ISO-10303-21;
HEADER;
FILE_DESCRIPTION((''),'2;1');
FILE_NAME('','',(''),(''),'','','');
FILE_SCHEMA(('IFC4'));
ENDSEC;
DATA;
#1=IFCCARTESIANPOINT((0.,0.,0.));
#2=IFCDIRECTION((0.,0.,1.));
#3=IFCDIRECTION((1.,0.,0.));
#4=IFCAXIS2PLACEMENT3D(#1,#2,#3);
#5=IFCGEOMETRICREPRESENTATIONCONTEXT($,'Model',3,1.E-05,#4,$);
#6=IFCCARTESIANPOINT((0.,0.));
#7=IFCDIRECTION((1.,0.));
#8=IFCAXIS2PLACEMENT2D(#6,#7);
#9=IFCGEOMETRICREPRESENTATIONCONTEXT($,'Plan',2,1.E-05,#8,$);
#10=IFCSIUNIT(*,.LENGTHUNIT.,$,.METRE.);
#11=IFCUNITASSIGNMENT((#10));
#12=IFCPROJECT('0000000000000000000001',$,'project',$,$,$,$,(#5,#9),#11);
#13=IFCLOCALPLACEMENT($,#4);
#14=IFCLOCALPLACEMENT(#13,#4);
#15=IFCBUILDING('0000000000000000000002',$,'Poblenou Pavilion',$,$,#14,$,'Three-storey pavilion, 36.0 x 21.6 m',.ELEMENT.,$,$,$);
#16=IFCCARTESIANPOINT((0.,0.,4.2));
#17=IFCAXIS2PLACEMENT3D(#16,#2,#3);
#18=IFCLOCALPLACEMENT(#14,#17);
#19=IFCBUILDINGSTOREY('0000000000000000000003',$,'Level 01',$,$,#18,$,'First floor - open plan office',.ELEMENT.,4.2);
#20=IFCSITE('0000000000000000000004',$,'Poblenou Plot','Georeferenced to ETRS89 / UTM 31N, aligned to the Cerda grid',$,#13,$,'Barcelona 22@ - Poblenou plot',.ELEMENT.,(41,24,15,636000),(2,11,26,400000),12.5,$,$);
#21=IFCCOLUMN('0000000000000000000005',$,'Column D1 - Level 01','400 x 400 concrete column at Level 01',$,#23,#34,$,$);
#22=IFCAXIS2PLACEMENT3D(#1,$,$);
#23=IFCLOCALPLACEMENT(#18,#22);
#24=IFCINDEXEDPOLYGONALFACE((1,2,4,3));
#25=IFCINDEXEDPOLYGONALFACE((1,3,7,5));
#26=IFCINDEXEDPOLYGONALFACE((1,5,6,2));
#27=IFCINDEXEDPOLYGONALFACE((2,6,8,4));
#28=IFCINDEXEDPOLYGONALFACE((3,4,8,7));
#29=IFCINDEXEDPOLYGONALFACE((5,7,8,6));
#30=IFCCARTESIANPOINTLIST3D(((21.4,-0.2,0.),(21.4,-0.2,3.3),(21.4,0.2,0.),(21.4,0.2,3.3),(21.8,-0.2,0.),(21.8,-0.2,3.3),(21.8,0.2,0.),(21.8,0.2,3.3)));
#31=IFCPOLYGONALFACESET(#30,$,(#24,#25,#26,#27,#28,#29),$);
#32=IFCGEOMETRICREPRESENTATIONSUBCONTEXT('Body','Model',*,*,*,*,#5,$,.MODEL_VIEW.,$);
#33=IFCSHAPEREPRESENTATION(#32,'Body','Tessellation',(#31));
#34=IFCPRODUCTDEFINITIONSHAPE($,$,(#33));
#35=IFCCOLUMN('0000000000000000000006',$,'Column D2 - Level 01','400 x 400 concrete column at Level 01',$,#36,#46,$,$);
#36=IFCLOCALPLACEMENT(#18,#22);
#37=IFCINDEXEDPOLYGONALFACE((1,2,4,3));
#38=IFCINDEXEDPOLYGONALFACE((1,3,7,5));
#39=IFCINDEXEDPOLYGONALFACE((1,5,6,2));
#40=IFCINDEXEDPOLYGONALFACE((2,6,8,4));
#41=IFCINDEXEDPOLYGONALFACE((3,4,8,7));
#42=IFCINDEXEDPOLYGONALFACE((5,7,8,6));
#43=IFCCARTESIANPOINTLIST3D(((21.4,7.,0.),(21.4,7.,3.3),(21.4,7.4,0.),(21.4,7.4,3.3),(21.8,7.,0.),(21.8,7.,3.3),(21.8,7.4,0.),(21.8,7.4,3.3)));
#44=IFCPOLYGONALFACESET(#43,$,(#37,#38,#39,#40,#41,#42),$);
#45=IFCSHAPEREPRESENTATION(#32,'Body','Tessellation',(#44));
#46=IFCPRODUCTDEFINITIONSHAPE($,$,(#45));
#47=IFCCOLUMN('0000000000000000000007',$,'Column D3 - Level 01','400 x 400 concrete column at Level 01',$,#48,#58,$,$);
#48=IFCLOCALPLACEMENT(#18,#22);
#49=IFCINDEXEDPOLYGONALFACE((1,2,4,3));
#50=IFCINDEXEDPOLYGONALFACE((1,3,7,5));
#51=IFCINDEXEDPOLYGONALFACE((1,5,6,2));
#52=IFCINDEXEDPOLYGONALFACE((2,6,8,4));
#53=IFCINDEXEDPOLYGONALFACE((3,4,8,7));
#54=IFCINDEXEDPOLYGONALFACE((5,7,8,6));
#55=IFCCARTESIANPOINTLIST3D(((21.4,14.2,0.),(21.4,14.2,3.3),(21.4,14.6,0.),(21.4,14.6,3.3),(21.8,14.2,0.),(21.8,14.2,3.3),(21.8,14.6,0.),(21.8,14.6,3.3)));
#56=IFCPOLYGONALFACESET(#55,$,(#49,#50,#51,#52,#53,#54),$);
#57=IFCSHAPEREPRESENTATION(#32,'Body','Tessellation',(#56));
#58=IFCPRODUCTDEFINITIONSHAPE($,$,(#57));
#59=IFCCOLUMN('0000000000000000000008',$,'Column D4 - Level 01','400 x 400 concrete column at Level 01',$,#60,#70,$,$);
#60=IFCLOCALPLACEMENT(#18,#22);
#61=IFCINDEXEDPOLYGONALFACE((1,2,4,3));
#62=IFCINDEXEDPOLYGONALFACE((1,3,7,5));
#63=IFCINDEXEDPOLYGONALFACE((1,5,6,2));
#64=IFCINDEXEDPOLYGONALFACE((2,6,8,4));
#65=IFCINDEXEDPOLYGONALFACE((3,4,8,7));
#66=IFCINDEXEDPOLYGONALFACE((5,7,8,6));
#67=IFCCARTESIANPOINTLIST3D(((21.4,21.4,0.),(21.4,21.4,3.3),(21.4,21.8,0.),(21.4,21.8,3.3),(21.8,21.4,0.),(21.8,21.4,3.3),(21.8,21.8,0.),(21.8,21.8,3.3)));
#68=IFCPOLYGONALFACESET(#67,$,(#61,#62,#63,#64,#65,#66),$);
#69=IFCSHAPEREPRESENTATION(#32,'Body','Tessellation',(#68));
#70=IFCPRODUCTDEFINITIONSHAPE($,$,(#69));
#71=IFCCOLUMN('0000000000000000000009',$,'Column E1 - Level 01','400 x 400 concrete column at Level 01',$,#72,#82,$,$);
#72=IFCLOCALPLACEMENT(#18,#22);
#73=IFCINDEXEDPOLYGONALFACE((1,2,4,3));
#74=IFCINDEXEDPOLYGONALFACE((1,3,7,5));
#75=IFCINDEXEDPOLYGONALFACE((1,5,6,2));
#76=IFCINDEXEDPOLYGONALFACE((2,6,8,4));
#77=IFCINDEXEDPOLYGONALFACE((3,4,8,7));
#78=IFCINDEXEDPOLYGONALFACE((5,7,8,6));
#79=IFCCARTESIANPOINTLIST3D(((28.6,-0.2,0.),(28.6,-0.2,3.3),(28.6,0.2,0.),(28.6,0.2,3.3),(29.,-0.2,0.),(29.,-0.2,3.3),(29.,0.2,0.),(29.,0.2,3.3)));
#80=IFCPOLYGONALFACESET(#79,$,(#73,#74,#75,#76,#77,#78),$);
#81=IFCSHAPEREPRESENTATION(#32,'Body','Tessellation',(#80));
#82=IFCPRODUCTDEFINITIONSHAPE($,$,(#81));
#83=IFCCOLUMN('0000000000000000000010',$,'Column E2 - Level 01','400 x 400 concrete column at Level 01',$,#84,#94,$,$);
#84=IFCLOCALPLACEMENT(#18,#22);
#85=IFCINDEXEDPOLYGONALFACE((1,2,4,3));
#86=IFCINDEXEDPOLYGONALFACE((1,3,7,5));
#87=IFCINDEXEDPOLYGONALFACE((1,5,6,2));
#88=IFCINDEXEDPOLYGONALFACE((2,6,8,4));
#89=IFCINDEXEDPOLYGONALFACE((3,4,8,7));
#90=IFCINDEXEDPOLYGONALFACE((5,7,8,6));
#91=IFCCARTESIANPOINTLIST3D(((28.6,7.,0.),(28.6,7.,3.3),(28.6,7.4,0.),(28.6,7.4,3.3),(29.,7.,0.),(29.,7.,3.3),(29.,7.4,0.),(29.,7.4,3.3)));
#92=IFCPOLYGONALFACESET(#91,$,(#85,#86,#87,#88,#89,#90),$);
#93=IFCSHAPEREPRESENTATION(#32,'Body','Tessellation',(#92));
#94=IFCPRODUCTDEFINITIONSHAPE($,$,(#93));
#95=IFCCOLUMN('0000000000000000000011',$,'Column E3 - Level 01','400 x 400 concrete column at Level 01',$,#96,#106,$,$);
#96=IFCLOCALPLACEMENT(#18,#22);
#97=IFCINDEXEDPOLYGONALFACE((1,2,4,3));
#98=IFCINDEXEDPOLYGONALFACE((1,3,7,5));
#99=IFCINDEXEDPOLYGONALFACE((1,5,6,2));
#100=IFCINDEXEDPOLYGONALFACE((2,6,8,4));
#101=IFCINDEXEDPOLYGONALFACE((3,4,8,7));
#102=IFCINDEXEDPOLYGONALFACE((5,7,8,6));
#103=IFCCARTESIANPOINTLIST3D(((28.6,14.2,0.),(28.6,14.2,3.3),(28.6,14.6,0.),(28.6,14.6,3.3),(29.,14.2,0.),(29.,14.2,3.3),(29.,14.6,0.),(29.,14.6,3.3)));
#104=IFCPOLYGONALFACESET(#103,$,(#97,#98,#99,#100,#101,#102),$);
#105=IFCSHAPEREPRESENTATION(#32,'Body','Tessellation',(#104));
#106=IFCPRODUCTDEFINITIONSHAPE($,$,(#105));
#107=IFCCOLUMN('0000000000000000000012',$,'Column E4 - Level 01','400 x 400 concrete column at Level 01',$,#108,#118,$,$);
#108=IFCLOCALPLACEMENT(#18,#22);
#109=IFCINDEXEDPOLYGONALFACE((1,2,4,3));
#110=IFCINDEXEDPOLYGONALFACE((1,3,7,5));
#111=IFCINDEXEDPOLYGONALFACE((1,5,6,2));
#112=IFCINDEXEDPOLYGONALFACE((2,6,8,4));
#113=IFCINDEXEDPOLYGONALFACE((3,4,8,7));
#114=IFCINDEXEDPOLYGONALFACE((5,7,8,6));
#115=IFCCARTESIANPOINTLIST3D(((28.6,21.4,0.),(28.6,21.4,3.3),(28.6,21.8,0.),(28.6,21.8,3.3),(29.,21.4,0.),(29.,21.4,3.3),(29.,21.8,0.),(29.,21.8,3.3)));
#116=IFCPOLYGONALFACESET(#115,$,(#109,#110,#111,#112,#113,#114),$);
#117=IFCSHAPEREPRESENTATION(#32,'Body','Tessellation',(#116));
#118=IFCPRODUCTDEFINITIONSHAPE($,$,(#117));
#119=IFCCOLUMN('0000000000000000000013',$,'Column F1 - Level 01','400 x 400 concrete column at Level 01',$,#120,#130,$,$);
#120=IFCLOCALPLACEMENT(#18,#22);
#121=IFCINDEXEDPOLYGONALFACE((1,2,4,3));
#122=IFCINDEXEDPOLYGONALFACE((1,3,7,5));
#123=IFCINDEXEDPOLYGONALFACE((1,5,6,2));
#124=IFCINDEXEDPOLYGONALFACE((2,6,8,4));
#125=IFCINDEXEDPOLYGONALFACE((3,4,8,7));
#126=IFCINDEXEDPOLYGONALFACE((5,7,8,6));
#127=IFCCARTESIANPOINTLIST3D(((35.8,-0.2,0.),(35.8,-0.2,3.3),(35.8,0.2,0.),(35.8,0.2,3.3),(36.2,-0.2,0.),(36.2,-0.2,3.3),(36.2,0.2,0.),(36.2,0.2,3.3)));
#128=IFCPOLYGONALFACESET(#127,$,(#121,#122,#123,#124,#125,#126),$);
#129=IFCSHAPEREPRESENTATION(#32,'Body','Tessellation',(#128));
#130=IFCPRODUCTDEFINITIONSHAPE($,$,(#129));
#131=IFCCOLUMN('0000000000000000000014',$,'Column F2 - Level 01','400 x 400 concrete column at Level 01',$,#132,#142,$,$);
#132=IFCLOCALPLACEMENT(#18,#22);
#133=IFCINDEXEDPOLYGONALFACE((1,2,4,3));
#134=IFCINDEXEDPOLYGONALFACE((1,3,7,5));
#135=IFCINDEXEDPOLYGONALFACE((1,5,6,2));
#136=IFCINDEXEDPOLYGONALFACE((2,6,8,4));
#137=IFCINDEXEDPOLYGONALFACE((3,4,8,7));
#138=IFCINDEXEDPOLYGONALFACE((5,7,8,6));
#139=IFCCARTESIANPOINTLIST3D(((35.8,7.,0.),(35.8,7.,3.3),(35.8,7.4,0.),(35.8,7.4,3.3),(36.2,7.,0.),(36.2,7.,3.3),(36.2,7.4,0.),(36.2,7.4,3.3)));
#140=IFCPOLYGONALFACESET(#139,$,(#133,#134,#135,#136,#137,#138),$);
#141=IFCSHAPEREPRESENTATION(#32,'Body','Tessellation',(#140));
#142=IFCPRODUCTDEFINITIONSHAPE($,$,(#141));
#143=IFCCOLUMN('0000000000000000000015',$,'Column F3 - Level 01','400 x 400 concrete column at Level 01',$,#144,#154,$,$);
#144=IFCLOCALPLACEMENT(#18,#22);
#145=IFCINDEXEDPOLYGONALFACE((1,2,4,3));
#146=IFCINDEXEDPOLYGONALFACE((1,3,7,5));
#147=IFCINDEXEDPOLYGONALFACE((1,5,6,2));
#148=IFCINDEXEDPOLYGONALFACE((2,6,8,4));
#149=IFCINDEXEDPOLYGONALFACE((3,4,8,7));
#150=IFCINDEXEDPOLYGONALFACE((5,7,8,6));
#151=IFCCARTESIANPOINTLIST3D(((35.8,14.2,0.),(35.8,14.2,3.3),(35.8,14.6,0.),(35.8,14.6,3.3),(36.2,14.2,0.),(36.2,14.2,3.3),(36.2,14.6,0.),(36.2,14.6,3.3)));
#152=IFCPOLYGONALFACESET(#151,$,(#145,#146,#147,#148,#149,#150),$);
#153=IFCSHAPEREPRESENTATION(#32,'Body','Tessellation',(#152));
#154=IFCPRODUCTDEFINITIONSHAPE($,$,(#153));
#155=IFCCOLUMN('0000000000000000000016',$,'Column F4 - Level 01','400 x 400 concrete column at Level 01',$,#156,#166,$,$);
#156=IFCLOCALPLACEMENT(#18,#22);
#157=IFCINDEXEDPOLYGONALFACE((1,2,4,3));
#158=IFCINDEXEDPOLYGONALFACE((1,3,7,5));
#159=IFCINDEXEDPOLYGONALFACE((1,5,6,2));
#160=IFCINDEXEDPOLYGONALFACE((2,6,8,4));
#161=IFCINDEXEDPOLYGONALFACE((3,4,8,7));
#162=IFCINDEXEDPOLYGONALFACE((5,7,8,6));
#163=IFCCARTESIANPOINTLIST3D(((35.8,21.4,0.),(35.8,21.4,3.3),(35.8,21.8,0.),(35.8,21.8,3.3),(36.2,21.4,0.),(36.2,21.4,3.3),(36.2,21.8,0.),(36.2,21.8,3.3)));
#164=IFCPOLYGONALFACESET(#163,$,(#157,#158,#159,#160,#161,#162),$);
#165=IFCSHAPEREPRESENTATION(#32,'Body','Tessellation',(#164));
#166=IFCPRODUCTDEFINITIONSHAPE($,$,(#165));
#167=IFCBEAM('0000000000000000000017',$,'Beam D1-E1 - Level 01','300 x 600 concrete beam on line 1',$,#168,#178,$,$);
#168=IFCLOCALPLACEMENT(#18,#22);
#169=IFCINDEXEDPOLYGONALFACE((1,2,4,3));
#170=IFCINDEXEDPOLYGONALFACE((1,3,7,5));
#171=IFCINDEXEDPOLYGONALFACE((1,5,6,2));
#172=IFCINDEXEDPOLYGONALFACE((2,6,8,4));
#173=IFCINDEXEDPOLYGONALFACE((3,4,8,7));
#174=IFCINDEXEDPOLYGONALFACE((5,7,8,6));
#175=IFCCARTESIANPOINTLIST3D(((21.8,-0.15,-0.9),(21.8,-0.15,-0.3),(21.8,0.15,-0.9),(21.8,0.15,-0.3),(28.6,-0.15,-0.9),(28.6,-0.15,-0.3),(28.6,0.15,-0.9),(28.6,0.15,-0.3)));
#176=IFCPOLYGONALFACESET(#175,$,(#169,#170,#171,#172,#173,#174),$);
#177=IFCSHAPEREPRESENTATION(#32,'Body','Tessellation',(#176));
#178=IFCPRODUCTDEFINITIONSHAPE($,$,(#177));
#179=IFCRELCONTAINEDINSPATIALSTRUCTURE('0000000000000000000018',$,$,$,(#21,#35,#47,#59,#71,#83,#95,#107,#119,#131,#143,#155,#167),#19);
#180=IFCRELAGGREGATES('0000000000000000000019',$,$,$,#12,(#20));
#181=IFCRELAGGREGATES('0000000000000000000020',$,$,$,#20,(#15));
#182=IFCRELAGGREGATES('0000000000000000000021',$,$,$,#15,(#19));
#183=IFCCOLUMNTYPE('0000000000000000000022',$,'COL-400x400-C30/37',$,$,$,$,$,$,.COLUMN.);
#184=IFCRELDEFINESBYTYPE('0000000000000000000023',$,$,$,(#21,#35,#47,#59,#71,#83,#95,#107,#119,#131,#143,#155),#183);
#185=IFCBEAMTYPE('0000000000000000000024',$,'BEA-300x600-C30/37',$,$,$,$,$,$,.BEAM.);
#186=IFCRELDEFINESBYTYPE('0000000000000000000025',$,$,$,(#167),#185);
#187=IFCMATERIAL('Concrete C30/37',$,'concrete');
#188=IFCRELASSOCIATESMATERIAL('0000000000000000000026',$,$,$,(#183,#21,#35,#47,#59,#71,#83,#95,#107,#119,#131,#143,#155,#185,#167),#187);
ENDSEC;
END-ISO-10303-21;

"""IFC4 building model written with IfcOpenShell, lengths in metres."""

from ifc_helpers import new_model, si_unit, frame, origin_with_axes, origin_2d_with_axis, place, context, subcontext, project, spatial, line, indexed_curve, rectangle, outline, extrude, material, material_profile, profile_set, profile_usage, type_object, element, save


model = new_model("IFC4")

# Units and contexts
model_context = context("Model", 3, precision=1e-05, world=origin_with_axes())
plan_context = context("Plan", 2, precision=1e-05, world=origin_2d_with_axis())
body_context = subcontext(model_context, "Body", "Model", "MODEL_VIEW")
ifc_project = project(units=[si_unit("LENGTHUNIT", "METRE")], contexts=[model_context, plan_context])

# Site, building, storey
site_placement = place(None, origin_with_axes())
site = spatial("IfcSite", under=ifc_project, at=site_placement, Name="Poblenou Plot", Description="Georeferenced to ETRS89 / UTM 31N, aligned to the Cerda grid", LongName="Barcelona 22@ - Poblenou plot", CompositionType="ELEMENT", RefLatitude=(41, 24, 15, 636000), RefLongitude=(2, 11, 26, 400000), RefElevation=12.5)
building_placement = place(site_placement, origin_with_axes())
building = spatial("IfcBuilding", under=site, at=building_placement, Name="Poblenou Pavilion", LongName="Three-storey pavilion, 36.0 x 21.6 m", CompositionType="ELEMENT")
storey_placement = place(building_placement, frame((0.0, 0.0, 4.2), z_axis=(0.0, 0.0, 1.0), x_axis=(1.0, 0.0, 0.0)))
storey = spatial("IfcBuildingStorey", under=building, at=storey_placement, Name="Level 01", LongName="First floor - open plan office", CompositionType="ELEMENT", Elevation=4.2)

# Columns
ifc_material = material(Name="Concrete C30/37", Category="concrete")
ifc_material_profile_1 = material_profile(ifc_material, rectangle(XDim=0.4, YDim=0.4))
ifc_profile_set_1 = profile_set([ifc_material_profile_1], Name="COL-400x400-C30/37")
ifc_profile_usage_1 = profile_usage(ifc_profile_set_1)
column_type = type_object("IfcColumnType", Name="COL-400x400-C30/37", PredefinedType="COLUMN", material=ifc_profile_set_1)
column_1_placement = place(storey_placement, frame((21.4, -0.2, 0.0), z_axis=(0.0, 0.0, 1.0), x_axis=(1.0, 0.0, 0.0)))
element("IfcColumn", 1, at=column_1_placement, inside=storey, type_object=column_type, material=ifc_profile_usage_1, Name="Column D1 - Level 01", Description="400 x 400 concrete column at Level 01", context=body_context, shape_type="SweptSolid", body=[
    extrude(outline(indexed_curve([(0.0, 0.0), (0.4, 0.0), (0.4, 0.4), (0.0, 0.4)], segments=[line(1, 2, 3, 4, 1)])), origin_with_axes(), (0.0, 0.0, 1.0), 3.3),
])
ifc_profile_usage_2 = profile_usage(ifc_profile_set_1)
column_2_placement = place(storey_placement, frame((21.4, 7.0, 0.0), z_axis=(0.0, 0.0, 1.0), x_axis=(1.0, 0.0, 0.0)))
element("IfcColumn", 2, at=column_2_placement, inside=storey, type_object=column_type, material=ifc_profile_usage_2, Name="Column D2 - Level 01", Description="400 x 400 concrete column at Level 01", context=body_context, shape_type="SweptSolid", body=[
    extrude(outline(indexed_curve([(0.0, 0.0), (0.4, 0.0), (0.4, 0.4), (0.0, 0.4)], segments=[line(1, 2, 3, 4, 1)])), origin_with_axes(), (0.0, 0.0, 1.0), 3.3),
])
ifc_profile_usage_3 = profile_usage(ifc_profile_set_1)
column_3_placement = place(storey_placement, frame((21.4, 14.2, 0.0), z_axis=(0.0, 0.0, 1.0), x_axis=(1.0, 0.0, 0.0)))
element("IfcColumn", 3, at=column_3_placement, inside=storey, type_object=column_type, material=ifc_profile_usage_3, Name="Column D3 - Level 01", Description="400 x 400 concrete column at Level 01", context=body_context, shape_type="SweptSolid", body=[
    extrude(outline(indexed_curve([(0.0, 0.0), (0.4, 0.0), (0.4, 0.4), (0.0, 0.4)], segments=[line(1, 2, 3, 4, 1)])), origin_with_axes(), (0.0, 0.0, 1.0), 3.3),
])
ifc_profile_usage_4 = profile_usage(ifc_profile_set_1)
column_4_placement = place(storey_placement, frame((21.4, 21.4, 0.0), z_axis=(0.0, 0.0, 1.0), x_axis=(1.0, 0.0, 0.0)))
element("IfcColumn", 4, at=column_4_placement, inside=storey, type_object=column_type, material=ifc_profile_usage_4, Name="Column D4 - Level 01", Description="400 x 400 concrete column at Level 01", context=body_context, shape_type="SweptSolid", body=[
    extrude(outline(indexed_curve([(0.0, 0.0), (0.4, 0.0), (0.4, 0.4), (0.0, 0.4)], segments=[line(1, 2, 3, 4, 1)])), origin_with_axes(), (0.0, 0.0, 1.0), 3.3),
])
ifc_profile_usage_5 = profile_usage(ifc_profile_set_1)
column_5_placement = place(storey_placement, frame((28.6, -0.2, 0.0), z_axis=(0.0, 0.0, 1.0), x_axis=(1.0, 0.0, 0.0)))
element("IfcColumn", 5, at=column_5_placement, inside=storey, type_object=column_type, material=ifc_profile_usage_5, Name="Column E1 - Level 01", Description="400 x 400 concrete column at Level 01", context=body_context, shape_type="SweptSolid", body=[
    extrude(outline(indexed_curve([(0.0, 0.0), (0.4, 0.0), (0.4, 0.4), (0.0, 0.4)], segments=[line(1, 2, 3, 4, 1)])), origin_with_axes(), (0.0, 0.0, 1.0), 3.3),
])
ifc_profile_usage_6 = profile_usage(ifc_profile_set_1)
column_6_placement = place(storey_placement, frame((28.6, 7.0, 0.0), z_axis=(0.0, 0.0, 1.0), x_axis=(1.0, 0.0, 0.0)))
element("IfcColumn", 6, at=column_6_placement, inside=storey, type_object=column_type, material=ifc_profile_usage_6, Name="Column E2 - Level 01", Description="400 x 400 concrete column at Level 01", context=body_context, shape_type="SweptSolid", body=[
    extrude(outline(indexed_curve([(0.0, 0.0), (0.4, 0.0), (0.4, 0.4), (0.0, 0.4)], segments=[line(1, 2, 3, 4, 1)])), origin_with_axes(), (0.0, 0.0, 1.0), 3.3),
])
ifc_profile_usage_7 = profile_usage(ifc_profile_set_1)
column_7_placement = place(storey_placement, frame((28.6, 14.2, 0.0), z_axis=(0.0, 0.0, 1.0), x_axis=(1.0, 0.0, 0.0)))
element("IfcColumn", 7, at=column_7_placement, inside=storey, type_object=column_type, material=ifc_profile_usage_7, Name="Column E3 - Level 01", Description="400 x 400 concrete column at Level 01", context=body_context, shape_type="SweptSolid", body=[
    extrude(outline(indexed_curve([(0.0, 0.0), (0.4, 0.0), (0.4, 0.4), (0.0, 0.4)], segments=[line(1, 2, 3, 4, 1)])), origin_with_axes(), (0.0, 0.0, 1.0), 3.3),
])
ifc_profile_usage_8 = profile_usage(ifc_profile_set_1)
column_8_placement = place(storey_placement, frame((28.6, 21.4, 0.0), z_axis=(0.0, 0.0, 1.0), x_axis=(1.0, 0.0, 0.0)))
element("IfcColumn", 8, at=column_8_placement, inside=storey, type_object=column_type, material=ifc_profile_usage_8, Name="Column E4 - Level 01", Description="400 x 400 concrete column at Level 01", context=body_context, shape_type="SweptSolid", body=[
    extrude(outline(indexed_curve([(0.0, 0.0), (0.4, 0.0), (0.4, 0.4), (0.0, 0.4)], segments=[line(1, 2, 3, 4, 1)])), origin_with_axes(), (0.0, 0.0, 1.0), 3.3),
])
ifc_profile_usage_9 = profile_usage(ifc_profile_set_1)
column_9_placement = place(storey_placement, frame((35.8, -0.2, 0.0), z_axis=(0.0, 0.0, 1.0), x_axis=(1.0, 0.0, 0.0)))
element("IfcColumn", 9, at=column_9_placement, inside=storey, type_object=column_type, material=ifc_profile_usage_9, Name="Column F1 - Level 01", Description="400 x 400 concrete column at Level 01", context=body_context, shape_type="SweptSolid", body=[
    extrude(outline(indexed_curve([(0.0, 0.0), (0.4, 0.0), (0.4, 0.4), (0.0, 0.4)], segments=[line(1, 2, 3, 4, 1)])), origin_with_axes(), (0.0, 0.0, 1.0), 3.3),
])
ifc_profile_usage_10 = profile_usage(ifc_profile_set_1)
column_10_placement = place(storey_placement, frame((35.8, 7.0, 0.0), z_axis=(0.0, 0.0, 1.0), x_axis=(1.0, 0.0, 0.0)))
element("IfcColumn", 10, at=column_10_placement, inside=storey, type_object=column_type, material=ifc_profile_usage_10, Name="Column F2 - Level 01", Description="400 x 400 concrete column at Level 01", context=body_context, shape_type="SweptSolid", body=[
    extrude(outline(indexed_curve([(0.0, 0.0), (0.4, 0.0), (0.4, 0.4), (0.0, 0.4)], segments=[line(1, 2, 3, 4, 1)])), origin_with_axes(), (0.0, 0.0, 1.0), 3.3),
])
ifc_profile_usage_11 = profile_usage(ifc_profile_set_1)
column_11_placement = place(storey_placement, frame((35.8, 14.2, 0.0), z_axis=(0.0, 0.0, 1.0), x_axis=(1.0, 0.0, 0.0)))
element("IfcColumn", 11, at=column_11_placement, inside=storey, type_object=column_type, material=ifc_profile_usage_11, Name="Column F3 - Level 01", Description="400 x 400 concrete column at Level 01", context=body_context, shape_type="SweptSolid", body=[
    extrude(outline(indexed_curve([(0.0, 0.0), (0.4, 0.0), (0.4, 0.4), (0.0, 0.4)], segments=[line(1, 2, 3, 4, 1)])), origin_with_axes(), (0.0, 0.0, 1.0), 3.3),
])
ifc_profile_usage_12 = profile_usage(ifc_profile_set_1)
column_12_placement = place(storey_placement, frame((35.8, 21.4, 0.0), z_axis=(0.0, 0.0, 1.0), x_axis=(1.0, 0.0, 0.0)))
element("IfcColumn", 12, at=column_12_placement, inside=storey, type_object=column_type, material=ifc_profile_usage_12, Name="Column F4 - Level 01", Description="400 x 400 concrete column at Level 01", context=body_context, shape_type="SweptSolid", body=[
    extrude(outline(indexed_curve([(0.0, 0.0), (0.4, 0.0), (0.4, 0.4), (0.0, 0.4)], segments=[line(1, 2, 3, 4, 1)])), origin_with_axes(), (0.0, 0.0, 1.0), 3.3),
])

# Beam
ifc_material_profile_2 = material_profile(ifc_material, rectangle(XDim=0.3, YDim=0.6))
ifc_profile_set_2 = profile_set([ifc_material_profile_2], Name="BEA-300x600-C30/37")
ifc_profile_usage_13 = profile_usage(ifc_profile_set_2)
beam_type = type_object("IfcBeamType", Name="BEA-300x600-C30/37", PredefinedType="BEAM", material=ifc_profile_set_2)
beam_1_placement = place(storey_placement, frame((21.8, -0.15, -0.9), z_axis=(1.0, 0.0, 0.0), x_axis=(0.0, 1.0, 0.0)))
element("IfcBeam", 13, at=beam_1_placement, inside=storey, type_object=beam_type, material=ifc_profile_usage_13, Name="Beam D1-E1 - Level 01", Description="300 x 600 concrete beam on line 1", context=body_context, shape_type="SweptSolid", body=[
    extrude(outline(indexed_curve([(0.0, 0.0), (0.3, 0.0), (0.3, 0.6), (0.0, 0.6)], segments=[line(1, 2, 3, 4, 1)])), origin_with_axes(), (0.0, 0.0, 1.0), 6.8),
])

save(model, "model.ifc")
